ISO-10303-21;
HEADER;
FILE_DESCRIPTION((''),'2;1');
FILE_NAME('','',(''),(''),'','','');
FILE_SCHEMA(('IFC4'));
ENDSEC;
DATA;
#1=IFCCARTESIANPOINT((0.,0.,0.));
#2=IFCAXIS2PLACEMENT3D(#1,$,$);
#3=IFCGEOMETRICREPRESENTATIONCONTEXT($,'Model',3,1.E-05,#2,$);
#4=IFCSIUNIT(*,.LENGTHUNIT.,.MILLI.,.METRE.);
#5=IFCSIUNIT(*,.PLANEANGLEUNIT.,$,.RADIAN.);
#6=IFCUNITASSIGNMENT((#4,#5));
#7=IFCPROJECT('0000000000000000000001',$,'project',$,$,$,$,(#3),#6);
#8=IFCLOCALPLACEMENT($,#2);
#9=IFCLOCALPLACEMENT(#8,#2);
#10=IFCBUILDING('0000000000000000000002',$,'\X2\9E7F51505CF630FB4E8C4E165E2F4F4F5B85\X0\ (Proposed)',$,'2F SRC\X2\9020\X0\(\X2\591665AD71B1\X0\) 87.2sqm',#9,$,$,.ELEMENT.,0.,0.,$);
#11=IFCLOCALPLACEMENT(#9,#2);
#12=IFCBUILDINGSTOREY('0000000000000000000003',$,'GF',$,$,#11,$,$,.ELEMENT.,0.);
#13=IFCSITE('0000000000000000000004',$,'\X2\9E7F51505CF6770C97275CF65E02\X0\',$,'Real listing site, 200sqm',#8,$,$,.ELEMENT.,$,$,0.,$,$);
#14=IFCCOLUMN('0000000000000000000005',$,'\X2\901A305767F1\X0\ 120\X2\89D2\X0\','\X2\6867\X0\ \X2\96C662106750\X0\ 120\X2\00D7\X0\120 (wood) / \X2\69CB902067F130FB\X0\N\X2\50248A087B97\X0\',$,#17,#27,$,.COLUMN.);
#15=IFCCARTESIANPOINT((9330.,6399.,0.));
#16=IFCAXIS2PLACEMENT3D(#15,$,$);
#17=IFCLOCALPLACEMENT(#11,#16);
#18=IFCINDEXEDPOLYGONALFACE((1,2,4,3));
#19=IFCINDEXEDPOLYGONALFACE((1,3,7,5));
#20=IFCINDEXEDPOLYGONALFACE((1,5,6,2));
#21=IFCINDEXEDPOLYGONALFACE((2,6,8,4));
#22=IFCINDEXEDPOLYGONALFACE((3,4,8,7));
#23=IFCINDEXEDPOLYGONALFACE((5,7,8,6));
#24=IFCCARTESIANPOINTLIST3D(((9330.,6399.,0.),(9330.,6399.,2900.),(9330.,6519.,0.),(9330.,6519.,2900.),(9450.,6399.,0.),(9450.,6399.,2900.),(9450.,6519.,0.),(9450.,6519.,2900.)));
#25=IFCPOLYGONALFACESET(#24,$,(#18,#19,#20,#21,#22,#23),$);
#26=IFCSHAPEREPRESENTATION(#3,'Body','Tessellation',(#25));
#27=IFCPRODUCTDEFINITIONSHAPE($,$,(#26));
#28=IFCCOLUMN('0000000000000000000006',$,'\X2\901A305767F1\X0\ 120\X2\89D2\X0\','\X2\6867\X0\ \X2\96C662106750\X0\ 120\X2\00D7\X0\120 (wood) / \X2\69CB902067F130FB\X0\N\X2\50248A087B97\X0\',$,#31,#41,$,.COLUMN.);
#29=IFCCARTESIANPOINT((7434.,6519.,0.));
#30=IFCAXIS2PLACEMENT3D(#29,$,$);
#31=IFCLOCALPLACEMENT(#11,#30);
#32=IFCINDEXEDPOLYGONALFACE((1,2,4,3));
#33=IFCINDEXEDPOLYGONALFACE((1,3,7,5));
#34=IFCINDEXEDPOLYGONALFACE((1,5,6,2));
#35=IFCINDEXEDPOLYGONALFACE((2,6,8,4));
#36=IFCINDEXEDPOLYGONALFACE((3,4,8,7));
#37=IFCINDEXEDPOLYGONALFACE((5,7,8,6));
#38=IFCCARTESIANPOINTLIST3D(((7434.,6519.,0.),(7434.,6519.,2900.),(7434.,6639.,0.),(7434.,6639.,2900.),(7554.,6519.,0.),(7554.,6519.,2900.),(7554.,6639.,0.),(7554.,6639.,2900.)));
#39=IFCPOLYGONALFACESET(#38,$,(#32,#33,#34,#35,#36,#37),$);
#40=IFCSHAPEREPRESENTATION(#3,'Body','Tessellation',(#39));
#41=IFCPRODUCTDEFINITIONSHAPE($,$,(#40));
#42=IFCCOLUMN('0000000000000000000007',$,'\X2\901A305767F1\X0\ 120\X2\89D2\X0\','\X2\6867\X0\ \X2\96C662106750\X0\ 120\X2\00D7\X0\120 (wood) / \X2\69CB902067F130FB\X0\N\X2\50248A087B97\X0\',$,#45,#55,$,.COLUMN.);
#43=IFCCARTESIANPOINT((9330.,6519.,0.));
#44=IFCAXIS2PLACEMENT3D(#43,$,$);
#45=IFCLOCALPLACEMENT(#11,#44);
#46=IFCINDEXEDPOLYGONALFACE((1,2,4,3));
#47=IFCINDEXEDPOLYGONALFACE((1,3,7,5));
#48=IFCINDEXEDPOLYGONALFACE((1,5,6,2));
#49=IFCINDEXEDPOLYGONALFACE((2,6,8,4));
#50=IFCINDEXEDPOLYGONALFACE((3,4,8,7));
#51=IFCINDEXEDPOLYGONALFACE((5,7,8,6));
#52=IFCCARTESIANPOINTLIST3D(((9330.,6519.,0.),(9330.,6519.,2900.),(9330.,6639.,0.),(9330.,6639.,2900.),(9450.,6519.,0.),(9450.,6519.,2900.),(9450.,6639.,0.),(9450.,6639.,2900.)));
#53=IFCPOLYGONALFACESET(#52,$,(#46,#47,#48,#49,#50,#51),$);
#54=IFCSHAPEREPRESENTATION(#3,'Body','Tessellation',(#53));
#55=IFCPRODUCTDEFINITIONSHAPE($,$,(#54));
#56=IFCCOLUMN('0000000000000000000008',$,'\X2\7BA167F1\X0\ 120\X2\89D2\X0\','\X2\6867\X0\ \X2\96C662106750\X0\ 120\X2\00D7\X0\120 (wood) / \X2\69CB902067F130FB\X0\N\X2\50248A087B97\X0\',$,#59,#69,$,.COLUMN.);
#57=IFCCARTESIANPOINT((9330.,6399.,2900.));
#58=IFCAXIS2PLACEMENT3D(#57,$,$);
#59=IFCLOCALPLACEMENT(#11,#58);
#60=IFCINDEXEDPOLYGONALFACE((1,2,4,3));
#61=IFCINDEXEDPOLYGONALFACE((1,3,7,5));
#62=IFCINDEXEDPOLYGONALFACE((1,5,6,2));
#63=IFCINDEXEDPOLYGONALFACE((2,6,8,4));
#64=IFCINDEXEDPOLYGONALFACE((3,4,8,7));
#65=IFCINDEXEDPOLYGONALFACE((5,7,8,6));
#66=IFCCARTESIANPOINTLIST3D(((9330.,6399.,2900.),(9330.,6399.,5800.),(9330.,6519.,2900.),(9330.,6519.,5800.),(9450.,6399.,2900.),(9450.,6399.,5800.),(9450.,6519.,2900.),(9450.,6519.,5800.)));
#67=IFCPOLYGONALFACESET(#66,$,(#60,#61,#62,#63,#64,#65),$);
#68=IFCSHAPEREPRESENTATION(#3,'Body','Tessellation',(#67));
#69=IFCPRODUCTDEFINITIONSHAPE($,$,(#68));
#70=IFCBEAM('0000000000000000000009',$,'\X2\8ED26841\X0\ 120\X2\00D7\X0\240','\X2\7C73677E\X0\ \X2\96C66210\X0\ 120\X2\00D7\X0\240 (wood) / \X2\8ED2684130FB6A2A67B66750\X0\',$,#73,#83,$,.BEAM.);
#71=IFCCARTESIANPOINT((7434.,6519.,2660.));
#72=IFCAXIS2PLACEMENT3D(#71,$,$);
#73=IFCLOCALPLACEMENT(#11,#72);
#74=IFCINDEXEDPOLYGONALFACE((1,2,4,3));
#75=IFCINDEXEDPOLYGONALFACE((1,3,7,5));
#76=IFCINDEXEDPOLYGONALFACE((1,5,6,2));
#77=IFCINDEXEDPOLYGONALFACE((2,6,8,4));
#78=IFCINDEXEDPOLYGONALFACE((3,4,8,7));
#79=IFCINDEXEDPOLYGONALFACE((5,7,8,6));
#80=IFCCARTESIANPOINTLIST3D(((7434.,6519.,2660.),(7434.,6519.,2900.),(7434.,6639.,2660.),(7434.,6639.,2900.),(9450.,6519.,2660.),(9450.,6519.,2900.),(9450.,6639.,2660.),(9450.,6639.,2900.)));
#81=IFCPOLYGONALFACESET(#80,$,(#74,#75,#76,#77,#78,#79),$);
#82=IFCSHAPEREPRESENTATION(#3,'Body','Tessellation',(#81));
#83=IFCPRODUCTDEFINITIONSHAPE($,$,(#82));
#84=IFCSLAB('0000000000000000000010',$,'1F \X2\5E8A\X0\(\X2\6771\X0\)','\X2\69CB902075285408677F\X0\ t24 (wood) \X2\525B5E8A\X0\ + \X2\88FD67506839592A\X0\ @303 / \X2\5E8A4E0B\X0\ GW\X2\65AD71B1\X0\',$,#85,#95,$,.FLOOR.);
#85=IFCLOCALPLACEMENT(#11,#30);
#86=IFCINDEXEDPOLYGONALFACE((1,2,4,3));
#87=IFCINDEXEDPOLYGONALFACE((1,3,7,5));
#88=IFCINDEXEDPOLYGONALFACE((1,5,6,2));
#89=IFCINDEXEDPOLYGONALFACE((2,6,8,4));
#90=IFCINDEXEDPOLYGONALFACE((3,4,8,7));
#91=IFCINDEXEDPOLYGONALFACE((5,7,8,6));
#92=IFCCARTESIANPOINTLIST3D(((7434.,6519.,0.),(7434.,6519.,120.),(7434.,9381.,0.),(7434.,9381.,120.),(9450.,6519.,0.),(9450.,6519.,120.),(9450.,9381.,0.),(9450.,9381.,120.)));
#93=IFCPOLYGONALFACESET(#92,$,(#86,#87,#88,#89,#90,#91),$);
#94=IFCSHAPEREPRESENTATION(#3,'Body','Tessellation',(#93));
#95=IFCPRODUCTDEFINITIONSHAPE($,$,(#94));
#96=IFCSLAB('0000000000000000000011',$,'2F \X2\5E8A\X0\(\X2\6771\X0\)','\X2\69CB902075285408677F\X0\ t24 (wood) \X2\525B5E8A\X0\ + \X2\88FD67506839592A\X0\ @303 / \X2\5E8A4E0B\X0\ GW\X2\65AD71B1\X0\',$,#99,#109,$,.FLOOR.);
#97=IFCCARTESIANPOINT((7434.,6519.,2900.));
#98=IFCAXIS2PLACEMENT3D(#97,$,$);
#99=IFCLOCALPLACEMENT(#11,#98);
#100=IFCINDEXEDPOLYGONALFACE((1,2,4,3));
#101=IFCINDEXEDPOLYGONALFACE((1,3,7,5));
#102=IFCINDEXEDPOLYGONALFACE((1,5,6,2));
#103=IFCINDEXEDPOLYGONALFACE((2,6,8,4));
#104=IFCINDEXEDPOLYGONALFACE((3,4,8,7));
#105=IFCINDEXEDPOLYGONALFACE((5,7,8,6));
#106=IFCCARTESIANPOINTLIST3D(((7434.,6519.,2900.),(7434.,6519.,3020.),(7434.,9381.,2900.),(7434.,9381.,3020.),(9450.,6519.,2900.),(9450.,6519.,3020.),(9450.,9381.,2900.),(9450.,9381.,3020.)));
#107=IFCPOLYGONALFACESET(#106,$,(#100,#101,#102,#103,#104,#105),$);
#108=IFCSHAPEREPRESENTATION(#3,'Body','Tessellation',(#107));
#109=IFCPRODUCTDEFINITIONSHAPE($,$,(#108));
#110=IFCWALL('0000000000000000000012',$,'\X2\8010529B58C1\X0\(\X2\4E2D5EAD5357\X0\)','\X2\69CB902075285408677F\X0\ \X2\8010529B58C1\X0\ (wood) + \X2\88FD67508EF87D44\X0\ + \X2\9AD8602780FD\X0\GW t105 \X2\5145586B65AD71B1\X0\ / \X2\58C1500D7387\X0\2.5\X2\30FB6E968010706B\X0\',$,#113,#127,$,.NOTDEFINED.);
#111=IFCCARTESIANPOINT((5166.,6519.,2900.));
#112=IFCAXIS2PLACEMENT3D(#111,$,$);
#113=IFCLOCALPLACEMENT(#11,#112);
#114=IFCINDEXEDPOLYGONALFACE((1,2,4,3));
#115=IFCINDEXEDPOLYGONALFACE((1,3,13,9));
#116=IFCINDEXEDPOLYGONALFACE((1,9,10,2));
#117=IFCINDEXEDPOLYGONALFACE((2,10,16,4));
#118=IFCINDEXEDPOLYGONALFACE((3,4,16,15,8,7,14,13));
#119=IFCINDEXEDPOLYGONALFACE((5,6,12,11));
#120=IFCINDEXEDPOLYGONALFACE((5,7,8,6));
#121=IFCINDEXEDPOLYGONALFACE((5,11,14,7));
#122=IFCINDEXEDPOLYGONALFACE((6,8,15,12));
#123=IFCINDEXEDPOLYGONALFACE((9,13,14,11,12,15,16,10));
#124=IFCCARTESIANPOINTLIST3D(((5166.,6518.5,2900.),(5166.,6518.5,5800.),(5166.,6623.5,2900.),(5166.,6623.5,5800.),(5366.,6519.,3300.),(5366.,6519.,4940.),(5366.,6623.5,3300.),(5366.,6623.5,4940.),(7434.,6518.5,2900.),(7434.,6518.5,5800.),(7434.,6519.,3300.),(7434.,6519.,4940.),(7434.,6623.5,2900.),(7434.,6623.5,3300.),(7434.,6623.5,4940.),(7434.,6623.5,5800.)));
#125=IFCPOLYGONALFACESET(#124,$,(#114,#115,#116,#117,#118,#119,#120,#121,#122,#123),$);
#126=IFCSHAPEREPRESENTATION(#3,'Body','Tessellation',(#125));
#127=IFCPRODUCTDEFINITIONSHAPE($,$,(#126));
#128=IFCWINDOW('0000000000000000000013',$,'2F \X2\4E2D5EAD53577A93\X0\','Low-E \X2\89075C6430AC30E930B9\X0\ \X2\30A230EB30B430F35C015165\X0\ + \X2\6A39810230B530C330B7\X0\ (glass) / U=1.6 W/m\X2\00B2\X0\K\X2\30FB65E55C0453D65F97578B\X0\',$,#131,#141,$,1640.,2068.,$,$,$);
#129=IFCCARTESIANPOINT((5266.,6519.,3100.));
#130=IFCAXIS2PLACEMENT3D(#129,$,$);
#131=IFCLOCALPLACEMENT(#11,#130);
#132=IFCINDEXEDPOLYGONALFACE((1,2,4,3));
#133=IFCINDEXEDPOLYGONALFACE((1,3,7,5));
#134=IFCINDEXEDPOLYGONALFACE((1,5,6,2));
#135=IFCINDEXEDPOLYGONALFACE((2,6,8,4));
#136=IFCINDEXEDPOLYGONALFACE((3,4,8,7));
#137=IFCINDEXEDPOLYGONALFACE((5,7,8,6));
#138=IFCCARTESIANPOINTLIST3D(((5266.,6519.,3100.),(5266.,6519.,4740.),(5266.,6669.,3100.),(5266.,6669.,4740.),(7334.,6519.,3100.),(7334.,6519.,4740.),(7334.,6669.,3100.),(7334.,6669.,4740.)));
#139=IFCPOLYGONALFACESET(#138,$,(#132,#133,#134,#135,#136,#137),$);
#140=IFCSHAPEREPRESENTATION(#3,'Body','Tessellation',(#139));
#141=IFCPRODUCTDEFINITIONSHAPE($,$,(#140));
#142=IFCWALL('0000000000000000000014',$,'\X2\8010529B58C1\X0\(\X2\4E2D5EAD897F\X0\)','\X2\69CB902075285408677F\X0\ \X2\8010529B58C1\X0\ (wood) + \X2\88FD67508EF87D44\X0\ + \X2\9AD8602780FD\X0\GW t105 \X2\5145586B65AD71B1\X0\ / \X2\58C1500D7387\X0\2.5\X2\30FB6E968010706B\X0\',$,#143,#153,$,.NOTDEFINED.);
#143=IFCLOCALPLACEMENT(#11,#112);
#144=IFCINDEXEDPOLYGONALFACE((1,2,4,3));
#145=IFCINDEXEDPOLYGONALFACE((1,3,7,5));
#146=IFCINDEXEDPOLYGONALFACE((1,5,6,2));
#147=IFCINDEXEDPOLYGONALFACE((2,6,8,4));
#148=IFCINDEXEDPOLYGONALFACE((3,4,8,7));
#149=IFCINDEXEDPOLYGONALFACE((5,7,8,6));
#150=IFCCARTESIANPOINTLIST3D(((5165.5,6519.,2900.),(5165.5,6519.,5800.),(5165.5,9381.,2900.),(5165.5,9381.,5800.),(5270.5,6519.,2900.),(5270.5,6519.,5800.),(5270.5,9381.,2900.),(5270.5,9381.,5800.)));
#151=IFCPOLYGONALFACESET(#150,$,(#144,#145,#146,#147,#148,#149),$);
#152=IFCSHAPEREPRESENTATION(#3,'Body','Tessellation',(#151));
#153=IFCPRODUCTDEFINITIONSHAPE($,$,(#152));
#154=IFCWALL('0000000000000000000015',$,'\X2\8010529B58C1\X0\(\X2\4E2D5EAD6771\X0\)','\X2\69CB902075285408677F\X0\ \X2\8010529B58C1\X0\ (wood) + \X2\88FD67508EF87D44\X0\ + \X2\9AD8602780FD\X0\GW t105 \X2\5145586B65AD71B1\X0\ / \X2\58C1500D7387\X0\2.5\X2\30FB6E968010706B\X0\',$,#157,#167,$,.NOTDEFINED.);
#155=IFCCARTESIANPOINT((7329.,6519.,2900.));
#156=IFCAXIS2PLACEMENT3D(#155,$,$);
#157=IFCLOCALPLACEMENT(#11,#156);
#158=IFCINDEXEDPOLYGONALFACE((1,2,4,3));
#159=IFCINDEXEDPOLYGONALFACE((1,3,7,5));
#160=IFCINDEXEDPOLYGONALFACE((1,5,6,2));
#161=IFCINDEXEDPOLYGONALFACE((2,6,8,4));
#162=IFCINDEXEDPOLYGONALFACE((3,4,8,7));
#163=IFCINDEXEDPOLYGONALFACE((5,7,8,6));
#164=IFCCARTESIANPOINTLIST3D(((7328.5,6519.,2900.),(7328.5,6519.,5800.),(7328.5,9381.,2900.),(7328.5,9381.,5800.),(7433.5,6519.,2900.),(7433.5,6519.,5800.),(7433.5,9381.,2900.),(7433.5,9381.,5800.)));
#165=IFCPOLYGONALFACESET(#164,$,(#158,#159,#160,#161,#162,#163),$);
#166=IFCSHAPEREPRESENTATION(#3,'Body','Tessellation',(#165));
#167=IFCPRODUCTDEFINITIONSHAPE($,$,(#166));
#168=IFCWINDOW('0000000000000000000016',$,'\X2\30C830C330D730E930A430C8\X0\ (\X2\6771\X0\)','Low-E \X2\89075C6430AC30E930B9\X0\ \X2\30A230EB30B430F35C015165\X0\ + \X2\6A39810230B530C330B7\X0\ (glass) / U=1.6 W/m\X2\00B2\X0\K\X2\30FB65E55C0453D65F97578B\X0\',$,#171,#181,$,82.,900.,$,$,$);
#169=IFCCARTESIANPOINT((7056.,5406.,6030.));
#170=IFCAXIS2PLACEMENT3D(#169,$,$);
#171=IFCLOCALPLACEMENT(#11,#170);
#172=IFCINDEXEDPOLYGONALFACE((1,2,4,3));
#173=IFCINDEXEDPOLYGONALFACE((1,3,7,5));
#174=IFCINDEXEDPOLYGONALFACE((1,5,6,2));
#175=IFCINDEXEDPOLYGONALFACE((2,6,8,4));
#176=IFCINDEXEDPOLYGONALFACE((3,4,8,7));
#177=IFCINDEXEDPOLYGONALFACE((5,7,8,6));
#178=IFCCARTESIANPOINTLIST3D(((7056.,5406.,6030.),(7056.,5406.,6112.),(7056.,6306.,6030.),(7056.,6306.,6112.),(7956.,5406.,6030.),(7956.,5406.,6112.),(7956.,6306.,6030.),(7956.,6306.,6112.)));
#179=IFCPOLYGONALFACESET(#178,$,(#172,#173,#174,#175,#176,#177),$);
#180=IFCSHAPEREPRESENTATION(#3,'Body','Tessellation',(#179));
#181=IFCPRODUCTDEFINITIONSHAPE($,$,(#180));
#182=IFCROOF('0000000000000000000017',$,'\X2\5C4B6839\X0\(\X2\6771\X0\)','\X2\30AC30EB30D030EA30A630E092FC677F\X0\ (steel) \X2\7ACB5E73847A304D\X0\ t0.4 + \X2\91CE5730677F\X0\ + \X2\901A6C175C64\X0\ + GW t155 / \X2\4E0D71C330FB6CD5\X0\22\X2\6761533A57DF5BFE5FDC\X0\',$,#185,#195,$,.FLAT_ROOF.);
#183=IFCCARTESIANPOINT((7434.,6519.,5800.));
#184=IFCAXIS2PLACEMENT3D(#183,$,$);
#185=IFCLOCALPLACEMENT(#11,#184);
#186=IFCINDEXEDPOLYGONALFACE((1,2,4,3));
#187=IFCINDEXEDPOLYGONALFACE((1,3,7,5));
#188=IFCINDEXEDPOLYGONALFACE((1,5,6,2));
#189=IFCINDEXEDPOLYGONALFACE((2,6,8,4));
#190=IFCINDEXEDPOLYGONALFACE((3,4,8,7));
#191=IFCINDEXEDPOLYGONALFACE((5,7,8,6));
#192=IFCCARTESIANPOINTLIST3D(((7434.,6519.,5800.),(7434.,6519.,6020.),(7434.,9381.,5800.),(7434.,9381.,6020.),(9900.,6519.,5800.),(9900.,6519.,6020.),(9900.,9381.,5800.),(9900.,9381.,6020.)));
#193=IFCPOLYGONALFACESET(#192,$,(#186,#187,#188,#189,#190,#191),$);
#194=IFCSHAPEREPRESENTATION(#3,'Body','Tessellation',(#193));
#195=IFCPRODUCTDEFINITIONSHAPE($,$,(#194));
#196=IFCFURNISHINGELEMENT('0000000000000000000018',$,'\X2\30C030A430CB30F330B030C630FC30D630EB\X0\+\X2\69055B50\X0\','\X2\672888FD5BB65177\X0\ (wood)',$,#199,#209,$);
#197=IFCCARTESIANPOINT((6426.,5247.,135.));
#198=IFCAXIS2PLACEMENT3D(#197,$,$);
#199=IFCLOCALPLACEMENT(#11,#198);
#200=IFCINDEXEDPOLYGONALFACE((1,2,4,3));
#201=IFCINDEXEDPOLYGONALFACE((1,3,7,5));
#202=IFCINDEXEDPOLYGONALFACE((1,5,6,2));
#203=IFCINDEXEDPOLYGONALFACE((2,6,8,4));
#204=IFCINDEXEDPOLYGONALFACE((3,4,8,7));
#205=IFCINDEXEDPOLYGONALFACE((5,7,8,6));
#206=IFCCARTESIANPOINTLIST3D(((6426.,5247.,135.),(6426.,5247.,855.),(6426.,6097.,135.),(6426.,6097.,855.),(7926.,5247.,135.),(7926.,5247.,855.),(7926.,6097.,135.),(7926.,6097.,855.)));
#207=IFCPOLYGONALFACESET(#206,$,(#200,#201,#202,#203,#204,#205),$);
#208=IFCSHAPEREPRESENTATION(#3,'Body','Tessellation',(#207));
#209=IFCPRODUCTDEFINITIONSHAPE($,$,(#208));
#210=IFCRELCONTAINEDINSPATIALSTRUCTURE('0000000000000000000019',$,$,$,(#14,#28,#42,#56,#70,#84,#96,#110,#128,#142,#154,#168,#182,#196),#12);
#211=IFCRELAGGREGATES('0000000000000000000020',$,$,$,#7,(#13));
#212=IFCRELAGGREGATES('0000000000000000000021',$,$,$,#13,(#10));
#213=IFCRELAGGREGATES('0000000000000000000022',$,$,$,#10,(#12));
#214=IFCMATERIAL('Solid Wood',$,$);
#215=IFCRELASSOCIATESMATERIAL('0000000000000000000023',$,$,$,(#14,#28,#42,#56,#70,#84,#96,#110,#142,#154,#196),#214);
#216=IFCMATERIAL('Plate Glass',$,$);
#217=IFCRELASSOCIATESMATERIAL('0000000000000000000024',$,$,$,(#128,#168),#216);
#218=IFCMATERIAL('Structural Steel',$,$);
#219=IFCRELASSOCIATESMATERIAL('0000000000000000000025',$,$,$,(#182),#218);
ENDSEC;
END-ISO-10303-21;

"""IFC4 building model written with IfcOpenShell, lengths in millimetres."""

from ifc_helpers import new_model, si_unit, frame, frame_2d, origin, place, context, project, spatial, rectangle, extrude, material, element, fill, save


model = new_model("IFC4")

# Units and contexts
model_context = context("Model", 3, precision=1e-05, world=origin())
ifc_project = project(units=[si_unit("LENGTHUNIT", "METRE", prefix="MILLI"), si_unit("PLANEANGLEUNIT", "RADIAN")], contexts=[model_context])

# Site, building, storey
site_placement = place(None, origin())
site = spatial("IfcSite", under=ifc_project, at=site_placement, Name="鹿児島県霧島市", ObjectType="Real listing site, 200sqm", CompositionType="ELEMENT", RefElevation=0.0)
building_placement = place(site_placement, origin())
building = spatial("IfcBuilding", under=site, at=building_placement, Name="鹿児島・二世帯住宅 (Proposed)", ObjectType="2F SRC造(外断熱) 87.2sqm", CompositionType="ELEMENT", ElevationOfRefHeight=0.0, ElevationOfTerrain=0.0)
storey_placement = place(building_placement, origin())
storey = spatial("IfcBuildingStorey", under=building, at=storey_placement, Name="GF", CompositionType="ELEMENT", Elevation=0.0)

# Columns
ifc_material_1 = material(Name="Solid Wood")
column_1_placement = place(storey_placement, frame((9330.0, 6399.0, 0.0)))
element("IfcColumn", 1, at=column_1_placement, inside=storey, material=ifc_material_1, Name="通し柱 120角", Description="桧 集成材 120×120 (wood) / 構造柱・N値計算", PredefinedType="COLUMN", context=model_context, shape_type="SweptSolid", body=[
    extrude(rectangle(XDim=120.0, YDim=120.0, at=frame_2d((60.0, 60.0))), frame((9330.0, 6399.0, 0.0)), (0.0, 0.0, 1.0), 2900.0),
])
column_2_placement = place(storey_placement, frame((7434.0, 6519.0, 0.0)))
element("IfcColumn", 2, at=column_2_placement, inside=storey, material=ifc_material_1, Name="通し柱 120角", Description="桧 集成材 120×120 (wood) / 構造柱・N値計算", PredefinedType="COLUMN", context=model_context, shape_type="SweptSolid", body=[
    extrude(rectangle(XDim=120.0, YDim=120.0, at=frame_2d((60.0, 60.0))), frame((7434.0, 6519.0, 0.0)), (0.0, 0.0, 1.0), 2900.0),
])
column_3_placement = place(storey_placement, frame((9330.0, 6519.0, 0.0)))
element("IfcColumn", 3, at=column_3_placement, inside=storey, material=ifc_material_1, Name="通し柱 120角", Description="桧 集成材 120×120 (wood) / 構造柱・N値計算", PredefinedType="COLUMN", context=model_context, shape_type="SweptSolid", body=[
    extrude(rectangle(XDim=120.0, YDim=120.0, at=frame_2d((60.0, 60.0))), frame((9330.0, 6519.0, 0.0)), (0.0, 0.0, 1.0), 2900.0),
])
column_4_placement = place(storey_placement, frame((9330.0, 6399.0, 2900.0)))
element("IfcColumn", 4, at=column_4_placement, inside=storey, material=ifc_material_1, Name="管柱 120角", Description="桧 集成材 120×120 (wood) / 構造柱・N値計算", PredefinedType="COLUMN", context=model_context, shape_type="SweptSolid", body=[
    extrude(rectangle(XDim=120.0, YDim=120.0, at=frame_2d((60.0, 60.0))), frame((9330.0, 6399.0, 2900.0)), (0.0, 0.0, 1.0), 2900.0),
])

# Beam
beam_1_placement = place(storey_placement, frame((7434.0, 6519.0, 2660.0)))
element("IfcBeam", 5, at=beam_1_placement, inside=storey, material=ifc_material_1, Name="軒桁 120×240", Description="米松 集成 120×240 (wood) / 軒桁・横架材", PredefinedType="BEAM", context=model_context, shape_type="SweptSolid", body=[
    extrude(rectangle(XDim=2016.0, YDim=120.0, at=frame_2d((1008.0, 60.0))), frame((7434.0, 6519.0, 2660.0)), (0.0, 0.0, 1.0), 240.0),
])

# Slabs
slab_1_placement = place(storey_placement, frame((7434.0, 6519.0, 0.0)))
element("IfcSlab", 6, at=slab_1_placement, inside=storey, material=ifc_material_1, Name="1F 床(東)", Description="構造用合板 t24 (wood) 剛床 + 製材根太 @303 / 床下 GW断熱", PredefinedType="FLOOR", context=model_context, shape_type="SweptSolid", body=[
    extrude(rectangle(XDim=2016.0, YDim=2862.0, at=frame_2d((1008.0, 1431.0))), frame((7434.0, 6519.0, 0.0)), (0.0, 0.0, 1.0), 120.0),
])
slab_2_placement = place(storey_placement, frame((7434.0, 6519.0, 2900.0)))
element("IfcSlab", 7, at=slab_2_placement, inside=storey, material=ifc_material_1, Name="2F 床(東)", Description="構造用合板 t24 (wood) 剛床 + 製材根太 @303 / 床下 GW断熱", PredefinedType="FLOOR", context=model_context, shape_type="SweptSolid", body=[
    extrude(rectangle(XDim=2016.0, YDim=2862.0, at=frame_2d((1008.0, 1431.0))), frame((7434.0, 6519.0, 2900.0)), (0.0, 0.0, 1.0), 120.0),
])

# Wall, opening, window
wall_1_placement = place(storey_placement, frame((5166.0, 6519.0, 2900.0)))
wall_1 = element("IfcWall", 8, at=wall_1_placement, inside=storey, material=ifc_material_1, Name="耐力壁(中庭南)", Description="構造用合板 耐力壁 (wood) + 製材軸組 + 高性能GW t105 充填断熱 / 壁倍率2.5・準耐火", PredefinedType="NOTDEFINED", context=model_context, shape_type="SweptSolid", body=[
    extrude(rectangle(XDim=2268.0, YDim=105.0, at=frame_2d((1134.0, 52.0))), frame((5166.0, 6519.0, 2900.0)), (0.0, 0.0, 1.0), 2900.0),
])
opening_placement = place(storey_placement, frame((5266.0, 6519.0, 3100.0)))
opening = element("IfcOpeningElement", 9, at=opening_placement, cuts=wall_1, PredefinedType="NOTDEFINED", context=model_context, shape_type="SweptSolid", body=[
    extrude(rectangle(XDim=2068.0, YDim=150.0, at=frame_2d((1034.0, 75.0))), frame((5266.0, 6519.0, 3100.0)), (0.0, 0.0, 1.0), 1640.0),
])
ifc_material_2 = material(Name="Plate Glass")
window_1_placement = place(storey_placement, frame((5266.0, 6519.0, 3100.0)))
window_1 = element("IfcWindow", 10, at=window_1_placement, inside=storey, material=ifc_material_2, Name="2F 中庭南窓", Description="Low-E 複層ガラス アルゴン封入 + 樹脂サッシ (glass) / U=1.6 W/m²K・日射取得型", OverallHeight=1640.0, OverallWidth=2068.0, context=model_context, shape_type="SweptSolid", body=[
    extrude(rectangle(XDim=2068.0, YDim=150.0, at=frame_2d((1034.0, 75.0))), frame((5266.0, 6519.0, 3100.0)), (0.0, 0.0, 1.0), 1640.0),
])
fill(opening, window_1)

# Walls
wall_2_placement = place(storey_placement, frame((5166.0, 6519.0, 2900.0)))
element("IfcWall", 11, at=wall_2_placement, inside=storey, material=ifc_material_1, Name="耐力壁(中庭西)", Description="構造用合板 耐力壁 (wood) + 製材軸組 + 高性能GW t105 充填断熱 / 壁倍率2.5・準耐火", PredefinedType="NOTDEFINED", context=model_context, shape_type="SweptSolid", body=[
    extrude(rectangle(XDim=105.0, YDim=2862.0, at=frame_2d((52.0, 1431.0))), frame((5166.0, 6519.0, 2900.0)), (0.0, 0.0, 1.0), 2900.0),
])
wall_3_placement = place(storey_placement, frame((7329.0, 6519.0, 2900.0)))
element("IfcWall", 12, at=wall_3_placement, inside=storey, material=ifc_material_1, Name="耐力壁(中庭東)", Description="構造用合板 耐力壁 (wood) + 製材軸組 + 高性能GW t105 充填断熱 / 壁倍率2.5・準耐火", PredefinedType="NOTDEFINED", context=model_context, shape_type="SweptSolid", body=[
    extrude(rectangle(XDim=105.0, YDim=2862.0, at=frame_2d((52.0, 1431.0))), frame((7329.0, 6519.0, 2900.0)), (0.0, 0.0, 1.0), 2900.0),
])

# Window
window_2_placement = place(storey_placement, frame((7056.0, 5406.0, 6030.0)))
element("IfcWindow", 13, at=window_2_placement, inside=storey, material=ifc_material_2, Name="トップライト (東)", Description="Low-E 複層ガラス アルゴン封入 + 樹脂サッシ (glass) / U=1.6 W/m²K・日射取得型", OverallHeight=82.0, OverallWidth=900.0, context=model_context, shape_type="SweptSolid", body=[
    extrude(rectangle(XDim=900.0, YDim=900.0, at=frame_2d((450.0, 450.0))), frame((7056.0, 5406.0, 6030.0)), (0.0, 0.0, 1.0), 82.0),
])

# Roof
ifc_material_3 = material(Name="Structural Steel")
for number, where, name in (
    (14, (7434.0, 6519.0, 5800.0), "屋根(東)"),
):
    element("IfcRoof", number, at=place(storey_placement, frame(where)), inside=storey, material=ifc_material_3, Name=name, Description="ガルバリウム鋼板 (steel) 立平葺き t0.4 + 野地板 + 通気層 + GW t155 / 不燃・法22条区域対応", PredefinedType="FLAT_ROOF", context=model_context, shape_type="SweptSolid", body=[
        extrude(rectangle(XDim=2466.0, YDim=2862.0, at=frame_2d((1233.0, 1431.0))), frame((7434.0, 6519.0, 5800.0)), (0.0, 0.0, 1.0), 220.0),
    ])

# Furnishing element
furnishing_1_placement = place(storey_placement, frame((6426.0, 5247.0, 135.0)))
element("IfcFurnishingElement", 15, at=furnishing_1_placement, inside=storey, material=ifc_material_1, Name="ダイニングテーブル+椅子", Description="木製家具 (wood)", context=model_context, shape_type="SweptSolid", body=[
    extrude(rectangle(XDim=1500.0, YDim=850.0, at=frame_2d((750.0, 425.0))), frame((6426.0, 5247.0, 135.0)), (0.0, 0.0, 1.0), 720.0),
])

save(model, "model.ifc")
